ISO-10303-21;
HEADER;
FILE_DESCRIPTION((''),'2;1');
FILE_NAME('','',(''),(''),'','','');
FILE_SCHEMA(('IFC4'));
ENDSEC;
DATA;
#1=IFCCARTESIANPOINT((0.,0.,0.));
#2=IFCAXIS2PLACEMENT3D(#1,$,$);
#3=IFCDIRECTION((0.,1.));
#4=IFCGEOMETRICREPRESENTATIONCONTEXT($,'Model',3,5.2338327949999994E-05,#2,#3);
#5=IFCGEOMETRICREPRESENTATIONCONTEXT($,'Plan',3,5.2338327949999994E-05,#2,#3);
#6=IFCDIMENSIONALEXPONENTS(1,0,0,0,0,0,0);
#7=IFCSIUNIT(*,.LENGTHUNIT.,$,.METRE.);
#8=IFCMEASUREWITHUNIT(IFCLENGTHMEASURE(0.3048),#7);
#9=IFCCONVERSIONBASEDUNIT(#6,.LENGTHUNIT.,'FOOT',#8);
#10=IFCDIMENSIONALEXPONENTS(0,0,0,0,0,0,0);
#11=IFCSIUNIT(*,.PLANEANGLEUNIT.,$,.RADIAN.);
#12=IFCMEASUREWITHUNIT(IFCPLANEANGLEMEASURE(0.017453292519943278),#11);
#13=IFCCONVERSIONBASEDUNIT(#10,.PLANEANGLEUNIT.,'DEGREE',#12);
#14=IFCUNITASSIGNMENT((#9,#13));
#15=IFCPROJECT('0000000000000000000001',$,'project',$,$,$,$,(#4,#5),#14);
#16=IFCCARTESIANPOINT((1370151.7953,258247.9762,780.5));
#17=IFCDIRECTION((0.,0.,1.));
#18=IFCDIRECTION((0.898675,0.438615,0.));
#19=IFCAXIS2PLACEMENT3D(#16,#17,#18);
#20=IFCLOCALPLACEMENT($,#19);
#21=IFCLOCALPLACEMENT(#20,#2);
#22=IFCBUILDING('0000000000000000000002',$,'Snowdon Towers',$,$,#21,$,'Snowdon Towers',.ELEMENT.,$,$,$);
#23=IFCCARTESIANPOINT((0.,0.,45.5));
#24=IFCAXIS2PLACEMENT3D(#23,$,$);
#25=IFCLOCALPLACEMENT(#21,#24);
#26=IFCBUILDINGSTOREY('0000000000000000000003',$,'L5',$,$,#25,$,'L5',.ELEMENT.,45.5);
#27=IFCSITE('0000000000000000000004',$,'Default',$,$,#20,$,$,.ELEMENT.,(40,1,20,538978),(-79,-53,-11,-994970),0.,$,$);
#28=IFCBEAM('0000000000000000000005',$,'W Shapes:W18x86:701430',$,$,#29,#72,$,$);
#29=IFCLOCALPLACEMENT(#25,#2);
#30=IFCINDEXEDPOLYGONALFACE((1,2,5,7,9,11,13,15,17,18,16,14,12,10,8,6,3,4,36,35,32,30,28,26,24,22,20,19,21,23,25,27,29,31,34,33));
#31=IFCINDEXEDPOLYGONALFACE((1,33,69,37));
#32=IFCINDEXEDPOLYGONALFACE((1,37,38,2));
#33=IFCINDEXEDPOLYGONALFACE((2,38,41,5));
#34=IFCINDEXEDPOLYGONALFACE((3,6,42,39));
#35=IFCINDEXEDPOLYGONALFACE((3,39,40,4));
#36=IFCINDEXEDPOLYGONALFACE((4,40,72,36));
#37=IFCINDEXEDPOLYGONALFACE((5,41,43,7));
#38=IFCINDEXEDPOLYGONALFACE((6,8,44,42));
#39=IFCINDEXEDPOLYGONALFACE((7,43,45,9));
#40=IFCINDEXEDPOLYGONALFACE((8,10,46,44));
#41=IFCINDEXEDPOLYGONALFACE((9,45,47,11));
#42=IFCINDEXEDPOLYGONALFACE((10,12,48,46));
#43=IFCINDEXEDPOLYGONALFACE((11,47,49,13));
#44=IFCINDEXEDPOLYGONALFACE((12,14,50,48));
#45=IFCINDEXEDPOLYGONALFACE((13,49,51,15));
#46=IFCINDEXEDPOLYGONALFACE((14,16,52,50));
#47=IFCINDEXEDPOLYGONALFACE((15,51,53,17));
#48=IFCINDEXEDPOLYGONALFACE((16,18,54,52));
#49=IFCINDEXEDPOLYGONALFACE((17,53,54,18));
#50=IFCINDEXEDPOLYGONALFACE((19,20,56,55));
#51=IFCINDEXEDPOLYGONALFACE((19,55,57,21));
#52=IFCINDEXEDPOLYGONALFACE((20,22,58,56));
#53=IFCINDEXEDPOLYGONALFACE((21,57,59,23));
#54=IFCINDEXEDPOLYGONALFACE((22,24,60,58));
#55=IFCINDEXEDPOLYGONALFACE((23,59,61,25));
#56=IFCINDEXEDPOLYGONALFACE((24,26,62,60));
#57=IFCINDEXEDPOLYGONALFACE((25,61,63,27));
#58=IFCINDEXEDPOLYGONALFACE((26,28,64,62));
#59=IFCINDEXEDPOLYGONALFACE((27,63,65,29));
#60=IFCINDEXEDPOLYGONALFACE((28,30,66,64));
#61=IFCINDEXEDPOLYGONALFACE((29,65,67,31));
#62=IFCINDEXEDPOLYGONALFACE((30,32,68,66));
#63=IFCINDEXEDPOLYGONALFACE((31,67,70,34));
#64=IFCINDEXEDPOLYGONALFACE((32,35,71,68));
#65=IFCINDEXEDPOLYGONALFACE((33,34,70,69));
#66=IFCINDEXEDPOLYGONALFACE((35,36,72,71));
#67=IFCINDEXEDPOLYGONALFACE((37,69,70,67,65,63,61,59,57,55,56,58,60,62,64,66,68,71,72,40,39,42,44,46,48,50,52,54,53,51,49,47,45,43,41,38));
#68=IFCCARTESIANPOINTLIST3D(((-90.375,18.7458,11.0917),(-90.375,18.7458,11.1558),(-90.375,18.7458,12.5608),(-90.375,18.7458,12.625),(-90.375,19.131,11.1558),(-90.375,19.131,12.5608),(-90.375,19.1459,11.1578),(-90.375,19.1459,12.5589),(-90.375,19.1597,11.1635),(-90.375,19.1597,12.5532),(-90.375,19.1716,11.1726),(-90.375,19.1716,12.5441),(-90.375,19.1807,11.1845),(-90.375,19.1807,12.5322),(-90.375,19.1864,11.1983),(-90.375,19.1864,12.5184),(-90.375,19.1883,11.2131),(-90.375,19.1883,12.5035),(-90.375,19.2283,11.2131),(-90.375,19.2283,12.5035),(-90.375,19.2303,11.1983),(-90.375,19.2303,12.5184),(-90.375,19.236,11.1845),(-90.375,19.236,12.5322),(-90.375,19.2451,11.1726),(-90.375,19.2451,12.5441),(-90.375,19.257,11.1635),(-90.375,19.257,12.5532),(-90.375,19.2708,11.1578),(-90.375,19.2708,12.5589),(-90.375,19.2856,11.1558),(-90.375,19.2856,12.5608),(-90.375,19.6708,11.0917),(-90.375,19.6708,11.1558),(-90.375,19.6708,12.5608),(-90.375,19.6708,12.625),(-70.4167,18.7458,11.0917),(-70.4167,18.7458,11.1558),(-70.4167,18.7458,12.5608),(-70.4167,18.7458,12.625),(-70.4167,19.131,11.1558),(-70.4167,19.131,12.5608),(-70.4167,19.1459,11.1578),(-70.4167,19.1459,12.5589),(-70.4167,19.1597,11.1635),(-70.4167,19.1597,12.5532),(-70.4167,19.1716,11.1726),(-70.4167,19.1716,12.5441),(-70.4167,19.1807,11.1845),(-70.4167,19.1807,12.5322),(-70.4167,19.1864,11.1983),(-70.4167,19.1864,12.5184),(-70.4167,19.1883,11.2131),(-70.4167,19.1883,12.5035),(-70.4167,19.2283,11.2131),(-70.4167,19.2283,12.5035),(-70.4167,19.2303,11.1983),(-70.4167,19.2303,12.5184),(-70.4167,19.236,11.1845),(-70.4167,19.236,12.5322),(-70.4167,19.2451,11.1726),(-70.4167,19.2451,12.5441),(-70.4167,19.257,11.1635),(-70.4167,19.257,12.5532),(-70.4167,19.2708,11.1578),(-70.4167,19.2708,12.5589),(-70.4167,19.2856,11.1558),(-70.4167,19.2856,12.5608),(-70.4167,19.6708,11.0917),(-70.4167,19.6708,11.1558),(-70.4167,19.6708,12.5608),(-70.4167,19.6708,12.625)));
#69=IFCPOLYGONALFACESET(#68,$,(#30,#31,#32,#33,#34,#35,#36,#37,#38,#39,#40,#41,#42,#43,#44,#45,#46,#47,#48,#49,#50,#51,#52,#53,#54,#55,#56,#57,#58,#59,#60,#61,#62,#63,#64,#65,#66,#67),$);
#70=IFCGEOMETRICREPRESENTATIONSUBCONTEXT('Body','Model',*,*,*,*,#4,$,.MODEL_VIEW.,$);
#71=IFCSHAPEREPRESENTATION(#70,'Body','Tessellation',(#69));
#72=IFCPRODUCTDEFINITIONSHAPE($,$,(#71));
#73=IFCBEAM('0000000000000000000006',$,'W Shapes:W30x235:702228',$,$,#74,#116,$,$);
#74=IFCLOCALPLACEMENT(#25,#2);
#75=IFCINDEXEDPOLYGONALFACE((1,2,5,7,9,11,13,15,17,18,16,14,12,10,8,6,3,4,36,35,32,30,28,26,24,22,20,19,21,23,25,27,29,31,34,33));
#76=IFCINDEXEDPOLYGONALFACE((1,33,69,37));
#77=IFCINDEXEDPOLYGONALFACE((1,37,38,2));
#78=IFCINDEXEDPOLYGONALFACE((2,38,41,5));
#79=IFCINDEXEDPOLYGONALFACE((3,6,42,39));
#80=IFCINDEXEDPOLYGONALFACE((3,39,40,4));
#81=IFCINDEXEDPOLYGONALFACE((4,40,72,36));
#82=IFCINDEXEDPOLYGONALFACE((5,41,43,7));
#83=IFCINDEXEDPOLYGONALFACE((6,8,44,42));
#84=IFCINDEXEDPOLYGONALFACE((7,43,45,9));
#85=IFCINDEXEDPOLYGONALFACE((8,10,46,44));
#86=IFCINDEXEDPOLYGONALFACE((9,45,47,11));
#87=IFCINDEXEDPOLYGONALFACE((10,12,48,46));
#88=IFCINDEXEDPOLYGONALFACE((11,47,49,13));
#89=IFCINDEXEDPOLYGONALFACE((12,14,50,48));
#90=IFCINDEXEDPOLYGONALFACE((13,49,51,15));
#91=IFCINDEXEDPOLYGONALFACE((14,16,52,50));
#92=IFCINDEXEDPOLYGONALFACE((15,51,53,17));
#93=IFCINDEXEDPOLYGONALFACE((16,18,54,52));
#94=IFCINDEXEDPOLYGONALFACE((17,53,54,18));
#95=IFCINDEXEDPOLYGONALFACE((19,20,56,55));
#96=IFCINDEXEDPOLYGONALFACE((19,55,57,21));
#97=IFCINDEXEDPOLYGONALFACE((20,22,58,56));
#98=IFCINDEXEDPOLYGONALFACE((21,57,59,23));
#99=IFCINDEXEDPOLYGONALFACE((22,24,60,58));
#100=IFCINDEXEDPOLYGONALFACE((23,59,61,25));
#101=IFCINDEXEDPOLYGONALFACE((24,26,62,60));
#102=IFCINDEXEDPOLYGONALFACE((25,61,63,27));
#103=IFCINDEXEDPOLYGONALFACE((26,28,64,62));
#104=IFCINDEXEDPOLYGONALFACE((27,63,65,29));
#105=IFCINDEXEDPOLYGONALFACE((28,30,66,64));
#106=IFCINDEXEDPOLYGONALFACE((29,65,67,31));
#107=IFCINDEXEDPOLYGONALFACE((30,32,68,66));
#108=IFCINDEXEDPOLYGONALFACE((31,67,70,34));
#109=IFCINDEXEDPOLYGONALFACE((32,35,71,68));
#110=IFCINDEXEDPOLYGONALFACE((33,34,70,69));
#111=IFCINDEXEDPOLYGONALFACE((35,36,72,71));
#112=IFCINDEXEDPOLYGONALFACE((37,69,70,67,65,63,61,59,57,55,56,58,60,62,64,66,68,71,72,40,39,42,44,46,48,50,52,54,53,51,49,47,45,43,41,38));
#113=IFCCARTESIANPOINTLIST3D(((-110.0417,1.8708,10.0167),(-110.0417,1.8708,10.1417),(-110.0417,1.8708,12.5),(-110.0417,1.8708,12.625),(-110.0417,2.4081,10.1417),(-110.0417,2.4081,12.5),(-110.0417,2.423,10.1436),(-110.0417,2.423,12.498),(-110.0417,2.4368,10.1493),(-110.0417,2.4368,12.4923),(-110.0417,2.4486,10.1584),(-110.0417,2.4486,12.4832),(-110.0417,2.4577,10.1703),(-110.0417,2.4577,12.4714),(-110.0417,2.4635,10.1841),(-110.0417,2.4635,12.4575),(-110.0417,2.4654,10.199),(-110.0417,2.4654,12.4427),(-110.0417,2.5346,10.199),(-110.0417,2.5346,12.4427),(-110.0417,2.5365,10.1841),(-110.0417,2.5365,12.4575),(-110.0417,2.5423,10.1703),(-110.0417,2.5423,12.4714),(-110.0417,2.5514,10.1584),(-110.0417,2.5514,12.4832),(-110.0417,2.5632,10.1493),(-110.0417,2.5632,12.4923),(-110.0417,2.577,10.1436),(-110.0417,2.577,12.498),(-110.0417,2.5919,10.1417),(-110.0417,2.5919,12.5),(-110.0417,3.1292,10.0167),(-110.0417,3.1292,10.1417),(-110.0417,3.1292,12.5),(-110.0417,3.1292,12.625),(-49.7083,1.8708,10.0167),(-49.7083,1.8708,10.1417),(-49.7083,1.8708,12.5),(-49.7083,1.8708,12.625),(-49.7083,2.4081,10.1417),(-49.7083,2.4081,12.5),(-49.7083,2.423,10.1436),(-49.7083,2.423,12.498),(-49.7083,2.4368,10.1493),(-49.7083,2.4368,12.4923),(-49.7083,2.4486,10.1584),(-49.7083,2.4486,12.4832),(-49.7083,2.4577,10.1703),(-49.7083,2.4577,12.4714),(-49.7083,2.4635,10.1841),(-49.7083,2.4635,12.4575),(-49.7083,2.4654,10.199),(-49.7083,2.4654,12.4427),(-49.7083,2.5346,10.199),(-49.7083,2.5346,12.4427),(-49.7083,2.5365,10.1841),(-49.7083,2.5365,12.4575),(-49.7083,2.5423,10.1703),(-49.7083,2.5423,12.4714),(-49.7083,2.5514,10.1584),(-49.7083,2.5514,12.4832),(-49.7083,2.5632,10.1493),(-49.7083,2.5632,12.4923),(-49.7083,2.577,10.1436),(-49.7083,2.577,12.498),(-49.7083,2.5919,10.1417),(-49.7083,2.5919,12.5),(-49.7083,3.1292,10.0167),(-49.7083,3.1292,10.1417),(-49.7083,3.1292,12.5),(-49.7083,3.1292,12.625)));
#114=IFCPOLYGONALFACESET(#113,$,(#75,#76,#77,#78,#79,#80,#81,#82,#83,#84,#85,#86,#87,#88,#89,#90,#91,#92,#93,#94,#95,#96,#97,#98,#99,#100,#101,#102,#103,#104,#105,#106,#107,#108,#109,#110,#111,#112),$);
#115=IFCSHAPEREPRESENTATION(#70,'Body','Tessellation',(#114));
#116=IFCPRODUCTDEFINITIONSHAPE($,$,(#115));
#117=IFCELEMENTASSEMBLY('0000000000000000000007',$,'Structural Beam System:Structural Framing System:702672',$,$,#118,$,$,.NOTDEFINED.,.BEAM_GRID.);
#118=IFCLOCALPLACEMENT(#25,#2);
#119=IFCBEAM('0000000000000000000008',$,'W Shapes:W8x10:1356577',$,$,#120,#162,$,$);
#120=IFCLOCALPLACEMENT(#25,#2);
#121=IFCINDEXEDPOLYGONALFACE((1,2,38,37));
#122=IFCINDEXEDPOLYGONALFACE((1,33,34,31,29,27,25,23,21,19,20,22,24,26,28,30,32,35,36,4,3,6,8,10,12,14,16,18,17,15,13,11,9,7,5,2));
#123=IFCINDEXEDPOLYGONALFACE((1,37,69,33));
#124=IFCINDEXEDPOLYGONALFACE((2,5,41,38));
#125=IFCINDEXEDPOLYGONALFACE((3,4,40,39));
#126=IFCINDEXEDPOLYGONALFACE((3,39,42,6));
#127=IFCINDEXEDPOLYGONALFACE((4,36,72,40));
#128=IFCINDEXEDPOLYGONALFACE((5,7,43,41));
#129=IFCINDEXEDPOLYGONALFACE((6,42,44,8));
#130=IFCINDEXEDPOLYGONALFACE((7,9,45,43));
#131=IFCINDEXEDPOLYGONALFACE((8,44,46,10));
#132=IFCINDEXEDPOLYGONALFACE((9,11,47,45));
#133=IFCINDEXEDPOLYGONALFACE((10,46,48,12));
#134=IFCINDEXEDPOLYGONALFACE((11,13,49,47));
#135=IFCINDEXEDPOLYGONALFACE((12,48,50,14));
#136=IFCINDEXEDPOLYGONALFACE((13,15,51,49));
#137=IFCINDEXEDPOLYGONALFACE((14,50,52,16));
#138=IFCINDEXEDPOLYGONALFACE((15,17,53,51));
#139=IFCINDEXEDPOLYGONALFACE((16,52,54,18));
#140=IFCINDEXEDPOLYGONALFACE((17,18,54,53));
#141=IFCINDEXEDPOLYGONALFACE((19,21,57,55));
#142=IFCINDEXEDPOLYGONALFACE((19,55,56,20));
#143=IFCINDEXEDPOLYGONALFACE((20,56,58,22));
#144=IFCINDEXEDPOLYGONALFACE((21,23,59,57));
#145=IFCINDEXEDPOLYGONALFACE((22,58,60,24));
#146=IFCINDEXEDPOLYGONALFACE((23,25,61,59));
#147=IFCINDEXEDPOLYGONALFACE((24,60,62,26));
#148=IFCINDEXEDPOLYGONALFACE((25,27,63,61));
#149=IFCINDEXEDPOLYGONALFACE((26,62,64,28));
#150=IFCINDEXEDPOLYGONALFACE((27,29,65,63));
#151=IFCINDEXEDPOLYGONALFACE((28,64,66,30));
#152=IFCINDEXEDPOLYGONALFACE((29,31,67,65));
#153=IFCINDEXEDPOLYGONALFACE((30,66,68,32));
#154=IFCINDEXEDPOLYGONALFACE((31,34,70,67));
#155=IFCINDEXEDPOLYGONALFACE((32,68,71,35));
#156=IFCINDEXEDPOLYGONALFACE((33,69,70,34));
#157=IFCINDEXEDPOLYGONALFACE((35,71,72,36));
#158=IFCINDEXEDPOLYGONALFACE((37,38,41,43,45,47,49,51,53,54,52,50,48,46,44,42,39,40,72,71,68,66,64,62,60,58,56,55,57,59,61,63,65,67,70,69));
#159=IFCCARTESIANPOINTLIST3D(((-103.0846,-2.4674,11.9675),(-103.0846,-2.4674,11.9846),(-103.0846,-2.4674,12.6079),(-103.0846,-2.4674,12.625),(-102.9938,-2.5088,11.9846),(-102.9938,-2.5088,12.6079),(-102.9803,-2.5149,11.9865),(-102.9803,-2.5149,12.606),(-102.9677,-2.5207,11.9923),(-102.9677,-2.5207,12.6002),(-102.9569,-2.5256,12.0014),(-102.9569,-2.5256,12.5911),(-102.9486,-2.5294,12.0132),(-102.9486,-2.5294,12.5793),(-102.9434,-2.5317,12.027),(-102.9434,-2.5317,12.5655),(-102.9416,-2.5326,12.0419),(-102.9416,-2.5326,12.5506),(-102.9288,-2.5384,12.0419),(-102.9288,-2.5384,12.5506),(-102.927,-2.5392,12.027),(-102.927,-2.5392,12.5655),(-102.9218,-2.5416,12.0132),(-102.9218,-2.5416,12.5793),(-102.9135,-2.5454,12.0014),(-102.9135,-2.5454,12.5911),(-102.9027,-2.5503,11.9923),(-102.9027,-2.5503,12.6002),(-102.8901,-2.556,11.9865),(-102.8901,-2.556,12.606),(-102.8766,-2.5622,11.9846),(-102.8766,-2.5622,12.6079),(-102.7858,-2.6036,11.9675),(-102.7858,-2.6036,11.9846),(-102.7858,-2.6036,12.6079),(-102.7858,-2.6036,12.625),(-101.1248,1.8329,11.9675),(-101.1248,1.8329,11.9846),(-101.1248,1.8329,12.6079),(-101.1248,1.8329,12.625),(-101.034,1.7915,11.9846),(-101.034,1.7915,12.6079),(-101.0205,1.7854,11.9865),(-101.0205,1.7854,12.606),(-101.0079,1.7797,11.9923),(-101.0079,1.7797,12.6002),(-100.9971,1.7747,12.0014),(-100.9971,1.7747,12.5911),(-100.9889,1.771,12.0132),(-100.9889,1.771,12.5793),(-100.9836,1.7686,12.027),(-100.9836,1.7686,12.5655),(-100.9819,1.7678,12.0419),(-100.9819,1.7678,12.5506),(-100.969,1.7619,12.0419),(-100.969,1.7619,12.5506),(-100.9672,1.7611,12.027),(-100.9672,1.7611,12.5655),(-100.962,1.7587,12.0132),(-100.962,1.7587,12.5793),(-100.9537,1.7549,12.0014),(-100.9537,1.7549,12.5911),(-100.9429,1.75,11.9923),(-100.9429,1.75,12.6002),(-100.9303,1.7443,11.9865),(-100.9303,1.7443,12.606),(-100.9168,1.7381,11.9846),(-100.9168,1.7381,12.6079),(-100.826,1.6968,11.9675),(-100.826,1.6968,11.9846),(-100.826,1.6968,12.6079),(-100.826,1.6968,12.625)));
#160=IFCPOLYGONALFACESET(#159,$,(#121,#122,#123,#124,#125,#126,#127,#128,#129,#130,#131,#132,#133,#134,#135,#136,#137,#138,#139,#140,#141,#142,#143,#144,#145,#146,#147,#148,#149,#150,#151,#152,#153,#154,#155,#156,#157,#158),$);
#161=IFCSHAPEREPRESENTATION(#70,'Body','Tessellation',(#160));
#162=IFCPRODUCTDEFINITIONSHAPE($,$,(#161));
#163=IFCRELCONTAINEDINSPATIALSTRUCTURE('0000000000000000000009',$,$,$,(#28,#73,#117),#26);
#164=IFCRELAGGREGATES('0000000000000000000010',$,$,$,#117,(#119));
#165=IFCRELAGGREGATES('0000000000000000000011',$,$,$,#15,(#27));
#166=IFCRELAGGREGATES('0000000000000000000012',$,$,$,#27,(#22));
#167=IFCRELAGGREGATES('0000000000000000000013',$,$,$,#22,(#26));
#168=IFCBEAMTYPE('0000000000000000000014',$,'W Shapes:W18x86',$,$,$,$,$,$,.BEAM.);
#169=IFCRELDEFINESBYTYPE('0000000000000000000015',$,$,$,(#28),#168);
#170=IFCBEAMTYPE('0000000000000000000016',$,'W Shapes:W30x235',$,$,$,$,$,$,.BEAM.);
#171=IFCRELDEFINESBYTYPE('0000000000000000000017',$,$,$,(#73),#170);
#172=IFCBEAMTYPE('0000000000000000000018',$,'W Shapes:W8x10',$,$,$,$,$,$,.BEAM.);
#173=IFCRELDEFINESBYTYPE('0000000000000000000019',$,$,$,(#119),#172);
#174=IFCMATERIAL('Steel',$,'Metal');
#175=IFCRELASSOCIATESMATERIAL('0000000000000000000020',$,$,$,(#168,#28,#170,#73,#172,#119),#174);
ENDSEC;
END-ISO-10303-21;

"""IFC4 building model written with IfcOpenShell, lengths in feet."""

from ifc_helpers import new_model, entity, si_unit, converted_unit, direction, frame, origin, place, context, subcontext, project, spatial, line, arc, indexed_curve, outline, extrude, source, transform, mapped, material, type_object, type_shapes, element, aggregate, save


model = new_model("IFC4")

# Units and contexts
model_context = context("Model", 3, precision=5.2338327949999994e-05, world=origin(), true_north=direction((0.0, 1.0)))
plan_context = context("Plan", 3, precision=5.2338327949999994e-05, world=origin(), true_north=direction((0.0, 1.0)))
body_context = subcontext(model_context, "Body", "Model", "MODEL_VIEW")
ifc_project = project(units=[converted_unit("LENGTHUNIT", "FOOT", entity("IfcLengthMeasure", 0.3048), si_unit("LENGTHUNIT", "METRE"), dimensions=[1, 0, 0, 0, 0, 0, 0]), converted_unit("PLANEANGLEUNIT", "DEGREE", entity("IfcPlaneAngleMeasure", 0.017453292519943278), si_unit("PLANEANGLEUNIT", "RADIAN"), dimensions=[0, 0, 0, 0, 0, 0, 0])], contexts=[model_context, plan_context])

# Site, building, storey
site_placement = place(None, frame((1370151.7953, 258247.9762, 780.5), z_axis=(0.0, 0.0, 1.0), x_axis=(0.898675, 0.438615, 0.0)))
site = spatial("IfcSite", under=ifc_project, at=site_placement, Name="Default", CompositionType="ELEMENT", RefLatitude=(40, 1, 20, 538978), RefLongitude=(-79, -53, -11, -994970), RefElevation=0.0)
building_placement = place(site_placement, origin())
building = spatial("IfcBuilding", under=site, at=building_placement, Name="Snowdon Towers", LongName="Snowdon Towers", CompositionType="ELEMENT")
storey_placement = place(building_placement, frame((0.0, 0.0, 45.5)))
storey = spatial("IfcBuildingStorey", under=building, at=storey_placement, Name="L5", LongName="L5", CompositionType="ELEMENT", Elevation=45.5)

# Beams
ifc_material_1 = material(Name="Steel", Category="Metal")
beam_type_1 = type_object("IfcBeamType", Name="W Shapes:W18x86", PredefinedType="BEAM", material=ifc_material_1)
shared_shape_1 = source(origin(), body_context, "Body", "SweptSolid", [
    extrude(outline(indexed_curve([(-0.7667, -0.4625), (-0.7025, -0.4625), (-0.7025, -0.0773), (-0.6857, -0.0368), (-0.6452, -0.02), (0.6452, -0.02), (0.6857, -0.0368), (0.7025, -0.0773), (0.7025, -0.4625), (0.7667, -0.4625), (0.7667, 0.4625), (0.7025, 0.4625), (0.7025, 0.0773), (0.6857, 0.0368), (0.6452, 0.02), (-0.6452, 0.02), (-0.6857, 0.0368), (-0.7025, 0.0773), (-0.7025, 0.4625), (-0.7667, 0.4625)], segments=[line(1, 2, 3), arc(3, 4, 5), line(5, 6), arc(6, 7, 8), line(8, 9, 10, 11, 12, 13), arc(13, 14, 15), line(15, 16), arc(16, 17, 18), line(18, 19, 20, 1)], self_intersect=False)), frame((-10.0, 0.0, 0.0), z_axis=(1.0, 0.0, 0.0), x_axis=(0.0, 0.0, -1.0)), (0.0, 0.0, 1.0), 19.9583),
])
type_shapes(beam_type_1, [shared_shape_1])
beam_1_placement = place(storey_placement, frame((-80.375, 19.2083, 11.8583)))
element("IfcBeam", 1, at=beam_1_placement, inside=storey, type_object=beam_type_1, material=ifc_material_1, Name="W Shapes:W18x86:701430", context=body_context, shape_type="MappedRepresentation", body=[
    mapped(shared_shape_1, transform((0.0, 0.0, 0.0), scale=1.0)),
])
beam_type_2 = type_object("IfcBeamType", Name="W Shapes:W30x235", PredefinedType="BEAM", material=ifc_material_1)
shared_shape_2 = source(origin(), body_context, "Body", "SweptSolid", [
    extrude(outline(indexed_curve([(-1.3042, -0.6292), (-1.1792, -0.6292), (-1.1792, -0.0919), (-1.1624, -0.0514), (-1.1219, -0.0346), (1.1219, -0.0346), (1.1624, -0.0514), (1.1792, -0.0919), (1.1792, -0.6292), (1.3042, -0.6292), (1.3042, 0.6292), (1.1792, 0.6292), (1.1792, 0.0919), (1.1624, 0.0514), (1.1219, 0.0346), (-1.1219, 0.0346), (-1.1624, 0.0514), (-1.1792, 0.0919), (-1.1792, 0.6292), (-1.3042, 0.6292)], segments=[line(1, 2, 3), arc(3, 4, 5), line(5, 6), arc(6, 7, 8), line(8, 9, 10, 11, 12, 13), arc(13, 14, 15), line(15, 16), arc(16, 17, 18), line(18, 19, 20, 1)], self_intersect=False)), frame((-29.9167, 0.0, 0.0), z_axis=(1.0, 0.0, 0.0), x_axis=(0.0, 0.0, -1.0)), (0.0, 0.0, 1.0), 60.3333),
])
type_shapes(beam_type_2, [shared_shape_2])
beam_2_placement = place(storey_placement, frame((-80.125, 2.5, 11.3208)))
element("IfcBeam", 2, at=beam_2_placement, inside=storey, type_object=beam_type_2, material=ifc_material_1, Name="W Shapes:W30x235:702228", context=body_context, shape_type="MappedRepresentation", body=[
    mapped(shared_shape_2, transform((0.0, 0.0, 0.0), scale=1.0)),
])

# Element assembly, beam
assembly_1_placement = place(storey_placement, origin())
assembly_1 = element("IfcElementAssembly", 3, at=assembly_1_placement, inside=storey, Name="Structural Beam System:Structural Framing System:702672", AssemblyPlace="NOTDEFINED", PredefinedType="BEAM_GRID")
beam_type_3 = type_object("IfcBeamType", Name="W Shapes:W8x10", PredefinedType="BEAM", material=ifc_material_1)
shared_shape_3 = source(origin(), body_context, "Body", "SweptSolid", [
    extrude(outline(indexed_curve([(-0.3287, -0.1642), (-0.3117, -0.1642), (-0.3117, -0.0644), (-0.2949, -0.0239), (-0.2544, -0.0071), (0.2544, -0.0071), (0.2949, -0.0239), (0.3117, -0.0644), (0.3117, -0.1642), (0.3288, -0.1642), (0.3288, 0.1642), (0.3117, 0.1642), (0.3117, 0.0644), (0.2949, 0.0239), (0.2544, 0.0071), (-0.2544, 0.0071), (-0.2949, 0.0239), (-0.3117, 0.0644), (-0.3117, 0.1642), (-0.3287, 0.1642)], segments=[line(1, 2, 3), arc(3, 4, 5), line(5, 6), arc(6, 7, 8), line(8, 9, 10, 11, 12, 13), arc(13, 14, 15), line(15, 16), arc(16, 17, 18), line(18, 19, 20, 1)], self_intersect=False)), frame((-2.6108, 0.0, 0.0), z_axis=(1.0, 0.0, 0.0), x_axis=(0.0, 0.0, -1.0)), (0.0, 0.0, 1.0), 4.7258),
])
type_shapes(beam_type_3, [shared_shape_3])
beam_3_placement = place(assembly_1_placement, frame((-101.8525, -0.1597, 12.2963), z_axis=(0.0, 0.0, 1.0), x_axis=(0.414693, 0.909961, 0.0)))
beam_3 = element("IfcBeam", 4, at=beam_3_placement, type_object=beam_type_3, material=ifc_material_1, Name="W Shapes:W8x10:1356577", context=body_context, shape_type="MappedRepresentation", body=[
    mapped(shared_shape_3, transform((0.0, 0.0, 0.0), scale=1.0)),
])
aggregate(assembly_1, [beam_3])

save(model, "model.ifc")
